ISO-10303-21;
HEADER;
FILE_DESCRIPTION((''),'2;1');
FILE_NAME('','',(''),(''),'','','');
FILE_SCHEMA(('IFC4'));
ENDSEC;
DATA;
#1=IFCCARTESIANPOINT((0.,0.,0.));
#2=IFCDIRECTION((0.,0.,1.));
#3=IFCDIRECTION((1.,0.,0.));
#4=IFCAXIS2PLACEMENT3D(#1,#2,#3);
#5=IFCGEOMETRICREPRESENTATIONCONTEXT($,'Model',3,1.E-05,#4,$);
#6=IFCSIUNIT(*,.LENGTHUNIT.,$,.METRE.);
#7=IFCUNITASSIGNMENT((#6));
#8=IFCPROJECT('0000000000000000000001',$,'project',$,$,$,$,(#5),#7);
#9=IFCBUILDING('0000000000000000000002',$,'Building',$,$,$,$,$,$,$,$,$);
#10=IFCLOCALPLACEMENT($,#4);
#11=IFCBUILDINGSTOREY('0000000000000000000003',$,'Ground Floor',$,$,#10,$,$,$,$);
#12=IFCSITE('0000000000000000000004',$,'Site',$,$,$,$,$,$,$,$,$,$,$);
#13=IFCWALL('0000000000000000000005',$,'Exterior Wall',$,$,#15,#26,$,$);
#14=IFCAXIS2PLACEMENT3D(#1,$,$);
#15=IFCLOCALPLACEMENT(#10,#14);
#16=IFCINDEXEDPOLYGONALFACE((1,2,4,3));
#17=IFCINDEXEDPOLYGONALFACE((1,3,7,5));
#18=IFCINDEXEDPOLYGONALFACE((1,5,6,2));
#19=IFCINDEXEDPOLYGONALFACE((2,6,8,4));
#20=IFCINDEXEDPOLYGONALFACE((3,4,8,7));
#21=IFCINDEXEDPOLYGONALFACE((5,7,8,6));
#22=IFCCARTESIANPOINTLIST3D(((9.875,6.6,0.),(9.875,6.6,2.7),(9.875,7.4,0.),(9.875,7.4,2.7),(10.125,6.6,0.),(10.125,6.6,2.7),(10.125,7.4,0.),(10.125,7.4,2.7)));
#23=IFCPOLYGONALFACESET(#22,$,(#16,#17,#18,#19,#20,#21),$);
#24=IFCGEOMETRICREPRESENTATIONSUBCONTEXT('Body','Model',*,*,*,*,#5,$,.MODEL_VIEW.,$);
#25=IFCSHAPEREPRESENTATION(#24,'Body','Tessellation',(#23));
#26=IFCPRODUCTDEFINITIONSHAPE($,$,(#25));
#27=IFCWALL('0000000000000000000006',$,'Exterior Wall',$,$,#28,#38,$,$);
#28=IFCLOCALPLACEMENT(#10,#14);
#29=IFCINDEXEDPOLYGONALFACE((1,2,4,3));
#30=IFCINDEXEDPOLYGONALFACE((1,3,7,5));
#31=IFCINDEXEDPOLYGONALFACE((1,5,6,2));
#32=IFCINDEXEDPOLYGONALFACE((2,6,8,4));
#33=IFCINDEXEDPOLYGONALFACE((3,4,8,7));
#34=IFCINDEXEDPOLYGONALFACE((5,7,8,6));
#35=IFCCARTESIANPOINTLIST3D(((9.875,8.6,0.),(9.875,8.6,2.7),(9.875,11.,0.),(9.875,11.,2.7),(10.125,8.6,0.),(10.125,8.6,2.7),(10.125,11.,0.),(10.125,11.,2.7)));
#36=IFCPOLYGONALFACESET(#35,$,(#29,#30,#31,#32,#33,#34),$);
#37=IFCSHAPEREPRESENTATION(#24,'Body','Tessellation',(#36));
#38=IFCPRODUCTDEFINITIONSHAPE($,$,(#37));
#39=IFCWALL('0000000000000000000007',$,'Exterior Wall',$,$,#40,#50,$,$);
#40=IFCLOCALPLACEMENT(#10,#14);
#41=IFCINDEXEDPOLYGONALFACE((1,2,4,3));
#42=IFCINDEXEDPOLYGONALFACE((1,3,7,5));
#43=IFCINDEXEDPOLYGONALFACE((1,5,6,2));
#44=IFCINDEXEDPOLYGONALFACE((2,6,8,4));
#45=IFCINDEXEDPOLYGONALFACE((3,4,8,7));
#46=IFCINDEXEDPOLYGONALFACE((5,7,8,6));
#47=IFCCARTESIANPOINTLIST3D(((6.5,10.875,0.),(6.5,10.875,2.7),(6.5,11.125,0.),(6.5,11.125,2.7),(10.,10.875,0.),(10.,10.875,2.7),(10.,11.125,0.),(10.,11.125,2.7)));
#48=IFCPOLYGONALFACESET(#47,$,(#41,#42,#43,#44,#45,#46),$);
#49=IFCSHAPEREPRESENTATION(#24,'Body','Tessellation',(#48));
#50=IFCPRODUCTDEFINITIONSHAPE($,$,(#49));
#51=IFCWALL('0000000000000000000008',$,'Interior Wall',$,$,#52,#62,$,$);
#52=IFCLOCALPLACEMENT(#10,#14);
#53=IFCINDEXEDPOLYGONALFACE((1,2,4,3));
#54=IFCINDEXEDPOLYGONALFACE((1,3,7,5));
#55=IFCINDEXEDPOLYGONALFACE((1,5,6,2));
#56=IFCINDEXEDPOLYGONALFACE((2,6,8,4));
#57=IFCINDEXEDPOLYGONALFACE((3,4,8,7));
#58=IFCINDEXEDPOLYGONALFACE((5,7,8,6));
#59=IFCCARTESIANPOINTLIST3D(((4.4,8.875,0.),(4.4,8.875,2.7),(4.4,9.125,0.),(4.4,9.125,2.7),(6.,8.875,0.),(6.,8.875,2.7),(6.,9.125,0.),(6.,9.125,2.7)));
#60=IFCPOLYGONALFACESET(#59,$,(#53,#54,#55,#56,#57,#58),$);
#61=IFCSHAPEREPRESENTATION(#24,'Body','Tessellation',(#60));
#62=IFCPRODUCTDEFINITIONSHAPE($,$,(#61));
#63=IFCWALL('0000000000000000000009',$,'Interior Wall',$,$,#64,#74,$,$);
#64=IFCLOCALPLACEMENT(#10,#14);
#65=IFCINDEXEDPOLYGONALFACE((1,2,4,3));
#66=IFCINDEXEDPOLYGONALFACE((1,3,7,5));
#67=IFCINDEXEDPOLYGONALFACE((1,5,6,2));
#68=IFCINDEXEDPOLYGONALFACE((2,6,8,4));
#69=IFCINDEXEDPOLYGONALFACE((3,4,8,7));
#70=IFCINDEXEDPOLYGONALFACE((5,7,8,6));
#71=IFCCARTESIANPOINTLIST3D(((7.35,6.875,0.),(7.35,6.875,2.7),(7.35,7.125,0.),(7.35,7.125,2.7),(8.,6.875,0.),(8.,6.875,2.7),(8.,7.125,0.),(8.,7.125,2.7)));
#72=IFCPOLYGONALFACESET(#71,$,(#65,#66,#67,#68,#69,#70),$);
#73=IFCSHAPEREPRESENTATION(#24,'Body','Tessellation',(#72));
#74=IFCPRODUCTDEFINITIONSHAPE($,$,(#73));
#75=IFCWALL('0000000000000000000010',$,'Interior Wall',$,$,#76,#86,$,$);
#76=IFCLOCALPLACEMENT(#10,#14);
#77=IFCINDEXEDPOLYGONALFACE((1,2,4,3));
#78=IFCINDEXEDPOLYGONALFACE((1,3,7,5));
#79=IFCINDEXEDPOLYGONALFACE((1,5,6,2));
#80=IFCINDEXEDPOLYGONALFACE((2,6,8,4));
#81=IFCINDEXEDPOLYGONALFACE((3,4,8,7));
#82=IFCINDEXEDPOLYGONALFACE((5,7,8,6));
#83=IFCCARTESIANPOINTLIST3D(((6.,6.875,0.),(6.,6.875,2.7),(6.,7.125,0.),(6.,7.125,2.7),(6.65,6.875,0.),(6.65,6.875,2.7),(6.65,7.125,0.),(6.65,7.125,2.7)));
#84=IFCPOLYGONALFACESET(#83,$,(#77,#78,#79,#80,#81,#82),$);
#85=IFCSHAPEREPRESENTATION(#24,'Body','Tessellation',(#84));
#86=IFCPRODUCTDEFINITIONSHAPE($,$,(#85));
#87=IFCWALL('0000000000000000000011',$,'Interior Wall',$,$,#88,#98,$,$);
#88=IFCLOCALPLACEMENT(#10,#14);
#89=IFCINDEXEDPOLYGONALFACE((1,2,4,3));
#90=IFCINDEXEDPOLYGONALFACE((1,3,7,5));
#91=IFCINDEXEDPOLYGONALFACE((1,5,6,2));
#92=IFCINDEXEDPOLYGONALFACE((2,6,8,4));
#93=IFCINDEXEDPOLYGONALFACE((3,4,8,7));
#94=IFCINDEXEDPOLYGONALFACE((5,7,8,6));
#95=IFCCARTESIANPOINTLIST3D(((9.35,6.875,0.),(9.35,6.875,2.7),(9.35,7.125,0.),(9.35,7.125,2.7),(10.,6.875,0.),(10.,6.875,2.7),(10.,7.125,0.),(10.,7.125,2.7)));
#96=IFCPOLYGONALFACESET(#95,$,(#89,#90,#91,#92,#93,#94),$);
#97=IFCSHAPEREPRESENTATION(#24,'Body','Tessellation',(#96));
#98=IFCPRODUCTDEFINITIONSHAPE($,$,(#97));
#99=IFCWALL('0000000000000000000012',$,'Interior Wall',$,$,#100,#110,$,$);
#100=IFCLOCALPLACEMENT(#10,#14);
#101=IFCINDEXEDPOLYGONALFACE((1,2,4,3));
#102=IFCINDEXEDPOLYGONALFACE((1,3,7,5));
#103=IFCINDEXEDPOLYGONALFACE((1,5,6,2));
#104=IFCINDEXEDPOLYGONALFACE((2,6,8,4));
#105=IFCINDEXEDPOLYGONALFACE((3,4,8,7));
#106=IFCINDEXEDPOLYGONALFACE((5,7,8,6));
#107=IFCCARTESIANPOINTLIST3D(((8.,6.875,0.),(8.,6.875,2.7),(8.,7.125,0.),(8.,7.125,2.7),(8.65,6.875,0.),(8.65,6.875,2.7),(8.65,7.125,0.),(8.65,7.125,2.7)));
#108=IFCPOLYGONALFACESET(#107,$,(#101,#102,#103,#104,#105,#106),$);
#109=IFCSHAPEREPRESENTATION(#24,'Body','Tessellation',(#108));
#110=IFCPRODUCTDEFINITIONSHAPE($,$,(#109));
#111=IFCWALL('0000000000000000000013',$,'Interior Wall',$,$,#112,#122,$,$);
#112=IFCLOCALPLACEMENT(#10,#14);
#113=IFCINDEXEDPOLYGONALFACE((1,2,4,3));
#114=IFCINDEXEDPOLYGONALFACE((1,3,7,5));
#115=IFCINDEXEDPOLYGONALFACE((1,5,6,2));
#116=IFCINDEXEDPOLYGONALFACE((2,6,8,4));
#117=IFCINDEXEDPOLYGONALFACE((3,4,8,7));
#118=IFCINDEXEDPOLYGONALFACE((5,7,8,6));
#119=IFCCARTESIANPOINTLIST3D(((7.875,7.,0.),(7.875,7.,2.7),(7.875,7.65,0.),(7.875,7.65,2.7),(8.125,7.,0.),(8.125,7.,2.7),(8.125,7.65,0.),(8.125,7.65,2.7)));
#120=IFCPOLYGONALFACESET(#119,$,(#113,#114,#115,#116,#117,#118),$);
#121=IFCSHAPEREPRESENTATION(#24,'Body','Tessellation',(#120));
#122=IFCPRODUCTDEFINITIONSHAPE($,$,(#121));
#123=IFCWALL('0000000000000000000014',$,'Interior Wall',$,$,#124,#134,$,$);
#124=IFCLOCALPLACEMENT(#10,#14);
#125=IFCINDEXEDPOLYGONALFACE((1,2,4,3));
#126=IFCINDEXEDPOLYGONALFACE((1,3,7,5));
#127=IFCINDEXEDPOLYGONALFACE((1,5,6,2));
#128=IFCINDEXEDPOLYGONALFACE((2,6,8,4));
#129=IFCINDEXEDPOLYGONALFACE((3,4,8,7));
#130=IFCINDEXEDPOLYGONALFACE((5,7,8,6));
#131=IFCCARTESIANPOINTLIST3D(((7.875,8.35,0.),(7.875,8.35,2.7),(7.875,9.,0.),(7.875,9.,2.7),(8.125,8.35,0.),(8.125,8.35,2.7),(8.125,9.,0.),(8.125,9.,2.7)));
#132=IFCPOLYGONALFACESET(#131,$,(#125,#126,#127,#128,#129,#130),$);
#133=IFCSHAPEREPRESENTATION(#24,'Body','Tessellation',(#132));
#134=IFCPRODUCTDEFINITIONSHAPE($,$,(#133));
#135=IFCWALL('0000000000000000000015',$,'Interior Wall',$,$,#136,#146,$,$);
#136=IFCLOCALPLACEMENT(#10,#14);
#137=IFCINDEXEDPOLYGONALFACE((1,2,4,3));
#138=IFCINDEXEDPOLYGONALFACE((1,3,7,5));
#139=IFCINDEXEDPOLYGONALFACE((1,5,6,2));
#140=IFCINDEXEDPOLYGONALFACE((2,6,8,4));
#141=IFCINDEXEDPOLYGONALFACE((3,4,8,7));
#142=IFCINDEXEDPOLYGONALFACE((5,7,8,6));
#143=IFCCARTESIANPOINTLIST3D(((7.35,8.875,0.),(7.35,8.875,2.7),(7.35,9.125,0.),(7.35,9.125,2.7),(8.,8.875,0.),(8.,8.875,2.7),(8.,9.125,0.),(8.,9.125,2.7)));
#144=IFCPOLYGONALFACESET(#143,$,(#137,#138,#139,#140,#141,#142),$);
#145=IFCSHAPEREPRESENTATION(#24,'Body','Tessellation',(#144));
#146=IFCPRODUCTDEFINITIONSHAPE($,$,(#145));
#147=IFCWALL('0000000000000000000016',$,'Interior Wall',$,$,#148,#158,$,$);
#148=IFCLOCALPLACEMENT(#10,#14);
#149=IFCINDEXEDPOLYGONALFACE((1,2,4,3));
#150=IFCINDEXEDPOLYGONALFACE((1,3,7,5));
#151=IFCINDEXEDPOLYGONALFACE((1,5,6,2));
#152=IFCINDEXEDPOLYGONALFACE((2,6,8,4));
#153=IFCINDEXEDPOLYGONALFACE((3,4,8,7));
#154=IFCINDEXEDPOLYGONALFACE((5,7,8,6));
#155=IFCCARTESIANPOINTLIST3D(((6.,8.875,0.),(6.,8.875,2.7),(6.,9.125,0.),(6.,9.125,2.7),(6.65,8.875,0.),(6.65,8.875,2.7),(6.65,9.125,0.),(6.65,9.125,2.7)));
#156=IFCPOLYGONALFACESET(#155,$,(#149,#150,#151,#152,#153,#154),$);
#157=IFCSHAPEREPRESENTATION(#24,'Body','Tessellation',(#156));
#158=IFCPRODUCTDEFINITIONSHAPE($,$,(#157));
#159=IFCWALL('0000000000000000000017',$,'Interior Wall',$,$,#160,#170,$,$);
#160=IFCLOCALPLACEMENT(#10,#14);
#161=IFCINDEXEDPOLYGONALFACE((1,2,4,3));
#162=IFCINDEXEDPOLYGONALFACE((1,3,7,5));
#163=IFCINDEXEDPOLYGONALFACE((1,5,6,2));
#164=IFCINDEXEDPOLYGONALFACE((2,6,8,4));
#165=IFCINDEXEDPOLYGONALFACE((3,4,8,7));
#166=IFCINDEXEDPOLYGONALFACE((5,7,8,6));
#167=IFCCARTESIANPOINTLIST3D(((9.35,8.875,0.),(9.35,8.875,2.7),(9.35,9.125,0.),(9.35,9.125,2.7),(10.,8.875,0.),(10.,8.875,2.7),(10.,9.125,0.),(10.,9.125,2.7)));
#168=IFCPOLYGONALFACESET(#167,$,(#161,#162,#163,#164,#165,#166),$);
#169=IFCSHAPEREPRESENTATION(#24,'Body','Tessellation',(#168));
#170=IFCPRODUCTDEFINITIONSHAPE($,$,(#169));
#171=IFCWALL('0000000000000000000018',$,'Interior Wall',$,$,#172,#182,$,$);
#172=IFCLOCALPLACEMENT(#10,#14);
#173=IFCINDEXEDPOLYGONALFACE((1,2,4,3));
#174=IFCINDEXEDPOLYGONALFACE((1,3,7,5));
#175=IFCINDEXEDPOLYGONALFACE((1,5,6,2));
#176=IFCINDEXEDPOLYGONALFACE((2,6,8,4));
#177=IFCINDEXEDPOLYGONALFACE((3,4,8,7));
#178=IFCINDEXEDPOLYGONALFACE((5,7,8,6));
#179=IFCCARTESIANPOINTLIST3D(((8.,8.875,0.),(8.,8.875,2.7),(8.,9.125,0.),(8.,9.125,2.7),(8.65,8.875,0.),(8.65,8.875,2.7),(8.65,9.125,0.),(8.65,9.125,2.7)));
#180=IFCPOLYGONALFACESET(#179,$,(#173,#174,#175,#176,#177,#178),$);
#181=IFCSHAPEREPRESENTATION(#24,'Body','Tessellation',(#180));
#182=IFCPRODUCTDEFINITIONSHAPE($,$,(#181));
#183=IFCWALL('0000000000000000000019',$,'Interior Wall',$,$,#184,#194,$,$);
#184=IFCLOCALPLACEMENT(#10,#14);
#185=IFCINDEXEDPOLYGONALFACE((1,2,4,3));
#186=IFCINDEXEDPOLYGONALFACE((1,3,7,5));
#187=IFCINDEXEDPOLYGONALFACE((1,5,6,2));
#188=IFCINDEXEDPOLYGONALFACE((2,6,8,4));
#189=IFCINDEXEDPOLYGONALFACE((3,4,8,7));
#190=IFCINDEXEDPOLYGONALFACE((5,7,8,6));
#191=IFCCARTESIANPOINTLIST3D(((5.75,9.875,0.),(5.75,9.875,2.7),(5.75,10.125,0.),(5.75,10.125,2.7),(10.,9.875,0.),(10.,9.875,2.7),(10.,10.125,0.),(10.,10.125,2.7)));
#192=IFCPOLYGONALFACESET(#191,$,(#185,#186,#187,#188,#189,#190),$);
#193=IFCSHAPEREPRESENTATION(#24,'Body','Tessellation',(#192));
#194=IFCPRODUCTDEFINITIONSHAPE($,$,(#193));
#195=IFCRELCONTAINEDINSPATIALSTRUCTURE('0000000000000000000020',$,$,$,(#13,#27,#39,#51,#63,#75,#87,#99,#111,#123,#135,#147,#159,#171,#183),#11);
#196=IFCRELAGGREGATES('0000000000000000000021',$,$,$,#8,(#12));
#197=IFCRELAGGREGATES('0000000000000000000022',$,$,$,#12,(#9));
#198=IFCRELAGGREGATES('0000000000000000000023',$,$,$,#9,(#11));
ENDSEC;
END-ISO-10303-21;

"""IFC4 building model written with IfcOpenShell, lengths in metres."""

from ifc_helpers import new_model, si_unit, frame, origin_with_axes, place, context, subcontext, project, spatial, indexed_curve, outline, extrude, element, save


model = new_model("IFC4")

# Units and contexts
model_context = context("Model", 3, precision=1e-05, world=origin_with_axes())
body_context = subcontext(model_context, "Body", "Model", "MODEL_VIEW")
ifc_project = project(units=[si_unit("LENGTHUNIT", "METRE")], contexts=[model_context])

# Site, building, storey
site = spatial("IfcSite", under=ifc_project, Name="Site")
building = spatial("IfcBuilding", under=site, Name="Building")
storey_placement = place(None, origin_with_axes())
storey = spatial("IfcBuildingStorey", under=building, at=storey_placement, Name="Ground Floor")

# Walls
wall_1_placement = place(storey_placement, frame((10.0, 6.6, 0.0), z_axis=(0.0, 0.0, 1.0), x_axis=(0.0, 1.0, 0.0)))
element("IfcWall", 1, at=wall_1_placement, inside=storey, Name="Exterior Wall", context=body_context, shape_type="SweptSolid", body=[
    extrude(outline(indexed_curve([(0.0, 0.0), (0.0, 0.25), (0.8, 0.25), (0.8, 0.0), (0.0, 0.0)], self_intersect=False)), frame((0.0, -0.125, 0.0), z_axis=(0.0, 0.0, 1.0), x_axis=(1.0, 0.0, 0.0)), (0.0, 0.0, 1.0), 2.7),
])
wall_2_placement = place(storey_placement, frame((10.0, 8.6, 0.0), z_axis=(0.0, 0.0, 1.0), x_axis=(0.0, 1.0, 0.0)))
element("IfcWall", 2, at=wall_2_placement, inside=storey, Name="Exterior Wall", context=body_context, shape_type="SweptSolid", body=[
    extrude(outline(indexed_curve([(0.0, 0.0), (0.0, 0.25), (2.4, 0.25), (2.4, 0.0), (0.0, 0.0)], self_intersect=False)), frame((0.0, -0.125, 0.0), z_axis=(0.0, 0.0, 1.0), x_axis=(1.0, 0.0, 0.0)), (0.0, 0.0, 1.0), 2.7),
])
wall_3_placement = place(storey_placement, frame((10.0, 11.0, 0.0), z_axis=(0.0, 0.0, 1.0), x_axis=(-1.0, 0.0, 0.0)))
element("IfcWall", 3, at=wall_3_placement, inside=storey, Name="Exterior Wall", context=body_context, shape_type="SweptSolid", body=[
    extrude(outline(indexed_curve([(0.0, 0.0), (0.0, 0.25), (3.5, 0.25), (3.5, 0.0), (0.0, 0.0)], self_intersect=False)), frame((0.0, -0.125, 0.0), z_axis=(0.0, 0.0, 1.0), x_axis=(1.0, 0.0, 0.0)), (0.0, 0.0, 1.0), 2.7),
])
wall_4_placement = place(storey_placement, frame((6.0, 9.0, 0.0), z_axis=(0.0, 0.0, 1.0), x_axis=(-1.0, 0.0, 0.0)))
element("IfcWall", 4, at=wall_4_placement, inside=storey, Name="Interior Wall", context=body_context, shape_type="SweptSolid", body=[
    extrude(outline(indexed_curve([(0.0, 0.0), (0.0, 0.25), (1.6, 0.25), (1.6, 0.0), (0.0, 0.0)], self_intersect=False)), frame((0.0, -0.125, 0.0), z_axis=(0.0, 0.0, 1.0), x_axis=(1.0, 0.0, 0.0)), (0.0, 0.0, 1.0), 2.7),
])
for number, where, z_axis, x_axis, name in (
    (5, (8.0, 7.0, 0.0), (0.0, 0.0, 1.0), (-1.0, 0.0, 0.0), "Interior Wall"),
    (6, (6.65, 7.0, 0.0), (0.0, 0.0, 1.0), (-1.0, 0.0, 0.0), "Interior Wall"),
    (7, (10.0, 7.0, 0.0), (0.0, 0.0, 1.0), (-1.0, 0.0, 0.0), "Interior Wall"),
    (8, (8.65, 7.0, 0.0), (0.0, 0.0, 1.0), (-1.0, 0.0, 0.0), "Interior Wall"),
    (9, (8.0, 7.0, 0.0), (0.0, 0.0, 1.0), (0.0, 1.0, 0.0), "Interior Wall"),
    (10, (8.0, 8.35, 0.0), (0.0, 0.0, 1.0), (0.0, 1.0, 0.0), "Interior Wall"),
    (11, (8.0, 9.0, 0.0), (0.0, 0.0, 1.0), (-1.0, 0.0, 0.0), "Interior Wall"),
    (12, (6.65, 9.0, 0.0), (0.0, 0.0, 1.0), (-1.0, 0.0, 0.0), "Interior Wall"),
    (13, (10.0, 9.0, 0.0), (0.0, 0.0, 1.0), (-1.0, 0.0, 0.0), "Interior Wall"),
    (14, (8.65, 9.0, 0.0), (0.0, 0.0, 1.0), (-1.0, 0.0, 0.0), "Interior Wall"),
):
    element("IfcWall", number, at=place(storey_placement, frame(where, z_axis=z_axis, x_axis=x_axis)), inside=storey, Name=name, context=body_context, shape_type="SweptSolid", body=[
        extrude(outline(indexed_curve([(0.0, 0.0), (0.0, 0.25), (0.65, 0.25), (0.65, 0.0), (0.0, 0.0)], self_intersect=False)), frame((0.0, -0.125, 0.0), z_axis=(0.0, 0.0, 1.0), x_axis=(1.0, 0.0, 0.0)), (0.0, 0.0, 1.0), 2.7),
    ])
wall_5_placement = place(storey_placement, frame((10.0, 10.0, 0.0), z_axis=(0.0, 0.0, 1.0), x_axis=(-1.0, 0.0, 0.0)))
element("IfcWall", 15, at=wall_5_placement, inside=storey, Name="Interior Wall", context=body_context, shape_type="SweptSolid", body=[
    extrude(outline(indexed_curve([(0.0, 0.0), (0.0, 0.25), (4.25, 0.25), (4.25, 0.0), (0.0, 0.0)], self_intersect=False)), frame((0.0, -0.125, 0.0), z_axis=(0.0, 0.0, 1.0), x_axis=(1.0, 0.0, 0.0)), (0.0, 0.0, 1.0), 2.7),
])

save(model, "model.ifc")
